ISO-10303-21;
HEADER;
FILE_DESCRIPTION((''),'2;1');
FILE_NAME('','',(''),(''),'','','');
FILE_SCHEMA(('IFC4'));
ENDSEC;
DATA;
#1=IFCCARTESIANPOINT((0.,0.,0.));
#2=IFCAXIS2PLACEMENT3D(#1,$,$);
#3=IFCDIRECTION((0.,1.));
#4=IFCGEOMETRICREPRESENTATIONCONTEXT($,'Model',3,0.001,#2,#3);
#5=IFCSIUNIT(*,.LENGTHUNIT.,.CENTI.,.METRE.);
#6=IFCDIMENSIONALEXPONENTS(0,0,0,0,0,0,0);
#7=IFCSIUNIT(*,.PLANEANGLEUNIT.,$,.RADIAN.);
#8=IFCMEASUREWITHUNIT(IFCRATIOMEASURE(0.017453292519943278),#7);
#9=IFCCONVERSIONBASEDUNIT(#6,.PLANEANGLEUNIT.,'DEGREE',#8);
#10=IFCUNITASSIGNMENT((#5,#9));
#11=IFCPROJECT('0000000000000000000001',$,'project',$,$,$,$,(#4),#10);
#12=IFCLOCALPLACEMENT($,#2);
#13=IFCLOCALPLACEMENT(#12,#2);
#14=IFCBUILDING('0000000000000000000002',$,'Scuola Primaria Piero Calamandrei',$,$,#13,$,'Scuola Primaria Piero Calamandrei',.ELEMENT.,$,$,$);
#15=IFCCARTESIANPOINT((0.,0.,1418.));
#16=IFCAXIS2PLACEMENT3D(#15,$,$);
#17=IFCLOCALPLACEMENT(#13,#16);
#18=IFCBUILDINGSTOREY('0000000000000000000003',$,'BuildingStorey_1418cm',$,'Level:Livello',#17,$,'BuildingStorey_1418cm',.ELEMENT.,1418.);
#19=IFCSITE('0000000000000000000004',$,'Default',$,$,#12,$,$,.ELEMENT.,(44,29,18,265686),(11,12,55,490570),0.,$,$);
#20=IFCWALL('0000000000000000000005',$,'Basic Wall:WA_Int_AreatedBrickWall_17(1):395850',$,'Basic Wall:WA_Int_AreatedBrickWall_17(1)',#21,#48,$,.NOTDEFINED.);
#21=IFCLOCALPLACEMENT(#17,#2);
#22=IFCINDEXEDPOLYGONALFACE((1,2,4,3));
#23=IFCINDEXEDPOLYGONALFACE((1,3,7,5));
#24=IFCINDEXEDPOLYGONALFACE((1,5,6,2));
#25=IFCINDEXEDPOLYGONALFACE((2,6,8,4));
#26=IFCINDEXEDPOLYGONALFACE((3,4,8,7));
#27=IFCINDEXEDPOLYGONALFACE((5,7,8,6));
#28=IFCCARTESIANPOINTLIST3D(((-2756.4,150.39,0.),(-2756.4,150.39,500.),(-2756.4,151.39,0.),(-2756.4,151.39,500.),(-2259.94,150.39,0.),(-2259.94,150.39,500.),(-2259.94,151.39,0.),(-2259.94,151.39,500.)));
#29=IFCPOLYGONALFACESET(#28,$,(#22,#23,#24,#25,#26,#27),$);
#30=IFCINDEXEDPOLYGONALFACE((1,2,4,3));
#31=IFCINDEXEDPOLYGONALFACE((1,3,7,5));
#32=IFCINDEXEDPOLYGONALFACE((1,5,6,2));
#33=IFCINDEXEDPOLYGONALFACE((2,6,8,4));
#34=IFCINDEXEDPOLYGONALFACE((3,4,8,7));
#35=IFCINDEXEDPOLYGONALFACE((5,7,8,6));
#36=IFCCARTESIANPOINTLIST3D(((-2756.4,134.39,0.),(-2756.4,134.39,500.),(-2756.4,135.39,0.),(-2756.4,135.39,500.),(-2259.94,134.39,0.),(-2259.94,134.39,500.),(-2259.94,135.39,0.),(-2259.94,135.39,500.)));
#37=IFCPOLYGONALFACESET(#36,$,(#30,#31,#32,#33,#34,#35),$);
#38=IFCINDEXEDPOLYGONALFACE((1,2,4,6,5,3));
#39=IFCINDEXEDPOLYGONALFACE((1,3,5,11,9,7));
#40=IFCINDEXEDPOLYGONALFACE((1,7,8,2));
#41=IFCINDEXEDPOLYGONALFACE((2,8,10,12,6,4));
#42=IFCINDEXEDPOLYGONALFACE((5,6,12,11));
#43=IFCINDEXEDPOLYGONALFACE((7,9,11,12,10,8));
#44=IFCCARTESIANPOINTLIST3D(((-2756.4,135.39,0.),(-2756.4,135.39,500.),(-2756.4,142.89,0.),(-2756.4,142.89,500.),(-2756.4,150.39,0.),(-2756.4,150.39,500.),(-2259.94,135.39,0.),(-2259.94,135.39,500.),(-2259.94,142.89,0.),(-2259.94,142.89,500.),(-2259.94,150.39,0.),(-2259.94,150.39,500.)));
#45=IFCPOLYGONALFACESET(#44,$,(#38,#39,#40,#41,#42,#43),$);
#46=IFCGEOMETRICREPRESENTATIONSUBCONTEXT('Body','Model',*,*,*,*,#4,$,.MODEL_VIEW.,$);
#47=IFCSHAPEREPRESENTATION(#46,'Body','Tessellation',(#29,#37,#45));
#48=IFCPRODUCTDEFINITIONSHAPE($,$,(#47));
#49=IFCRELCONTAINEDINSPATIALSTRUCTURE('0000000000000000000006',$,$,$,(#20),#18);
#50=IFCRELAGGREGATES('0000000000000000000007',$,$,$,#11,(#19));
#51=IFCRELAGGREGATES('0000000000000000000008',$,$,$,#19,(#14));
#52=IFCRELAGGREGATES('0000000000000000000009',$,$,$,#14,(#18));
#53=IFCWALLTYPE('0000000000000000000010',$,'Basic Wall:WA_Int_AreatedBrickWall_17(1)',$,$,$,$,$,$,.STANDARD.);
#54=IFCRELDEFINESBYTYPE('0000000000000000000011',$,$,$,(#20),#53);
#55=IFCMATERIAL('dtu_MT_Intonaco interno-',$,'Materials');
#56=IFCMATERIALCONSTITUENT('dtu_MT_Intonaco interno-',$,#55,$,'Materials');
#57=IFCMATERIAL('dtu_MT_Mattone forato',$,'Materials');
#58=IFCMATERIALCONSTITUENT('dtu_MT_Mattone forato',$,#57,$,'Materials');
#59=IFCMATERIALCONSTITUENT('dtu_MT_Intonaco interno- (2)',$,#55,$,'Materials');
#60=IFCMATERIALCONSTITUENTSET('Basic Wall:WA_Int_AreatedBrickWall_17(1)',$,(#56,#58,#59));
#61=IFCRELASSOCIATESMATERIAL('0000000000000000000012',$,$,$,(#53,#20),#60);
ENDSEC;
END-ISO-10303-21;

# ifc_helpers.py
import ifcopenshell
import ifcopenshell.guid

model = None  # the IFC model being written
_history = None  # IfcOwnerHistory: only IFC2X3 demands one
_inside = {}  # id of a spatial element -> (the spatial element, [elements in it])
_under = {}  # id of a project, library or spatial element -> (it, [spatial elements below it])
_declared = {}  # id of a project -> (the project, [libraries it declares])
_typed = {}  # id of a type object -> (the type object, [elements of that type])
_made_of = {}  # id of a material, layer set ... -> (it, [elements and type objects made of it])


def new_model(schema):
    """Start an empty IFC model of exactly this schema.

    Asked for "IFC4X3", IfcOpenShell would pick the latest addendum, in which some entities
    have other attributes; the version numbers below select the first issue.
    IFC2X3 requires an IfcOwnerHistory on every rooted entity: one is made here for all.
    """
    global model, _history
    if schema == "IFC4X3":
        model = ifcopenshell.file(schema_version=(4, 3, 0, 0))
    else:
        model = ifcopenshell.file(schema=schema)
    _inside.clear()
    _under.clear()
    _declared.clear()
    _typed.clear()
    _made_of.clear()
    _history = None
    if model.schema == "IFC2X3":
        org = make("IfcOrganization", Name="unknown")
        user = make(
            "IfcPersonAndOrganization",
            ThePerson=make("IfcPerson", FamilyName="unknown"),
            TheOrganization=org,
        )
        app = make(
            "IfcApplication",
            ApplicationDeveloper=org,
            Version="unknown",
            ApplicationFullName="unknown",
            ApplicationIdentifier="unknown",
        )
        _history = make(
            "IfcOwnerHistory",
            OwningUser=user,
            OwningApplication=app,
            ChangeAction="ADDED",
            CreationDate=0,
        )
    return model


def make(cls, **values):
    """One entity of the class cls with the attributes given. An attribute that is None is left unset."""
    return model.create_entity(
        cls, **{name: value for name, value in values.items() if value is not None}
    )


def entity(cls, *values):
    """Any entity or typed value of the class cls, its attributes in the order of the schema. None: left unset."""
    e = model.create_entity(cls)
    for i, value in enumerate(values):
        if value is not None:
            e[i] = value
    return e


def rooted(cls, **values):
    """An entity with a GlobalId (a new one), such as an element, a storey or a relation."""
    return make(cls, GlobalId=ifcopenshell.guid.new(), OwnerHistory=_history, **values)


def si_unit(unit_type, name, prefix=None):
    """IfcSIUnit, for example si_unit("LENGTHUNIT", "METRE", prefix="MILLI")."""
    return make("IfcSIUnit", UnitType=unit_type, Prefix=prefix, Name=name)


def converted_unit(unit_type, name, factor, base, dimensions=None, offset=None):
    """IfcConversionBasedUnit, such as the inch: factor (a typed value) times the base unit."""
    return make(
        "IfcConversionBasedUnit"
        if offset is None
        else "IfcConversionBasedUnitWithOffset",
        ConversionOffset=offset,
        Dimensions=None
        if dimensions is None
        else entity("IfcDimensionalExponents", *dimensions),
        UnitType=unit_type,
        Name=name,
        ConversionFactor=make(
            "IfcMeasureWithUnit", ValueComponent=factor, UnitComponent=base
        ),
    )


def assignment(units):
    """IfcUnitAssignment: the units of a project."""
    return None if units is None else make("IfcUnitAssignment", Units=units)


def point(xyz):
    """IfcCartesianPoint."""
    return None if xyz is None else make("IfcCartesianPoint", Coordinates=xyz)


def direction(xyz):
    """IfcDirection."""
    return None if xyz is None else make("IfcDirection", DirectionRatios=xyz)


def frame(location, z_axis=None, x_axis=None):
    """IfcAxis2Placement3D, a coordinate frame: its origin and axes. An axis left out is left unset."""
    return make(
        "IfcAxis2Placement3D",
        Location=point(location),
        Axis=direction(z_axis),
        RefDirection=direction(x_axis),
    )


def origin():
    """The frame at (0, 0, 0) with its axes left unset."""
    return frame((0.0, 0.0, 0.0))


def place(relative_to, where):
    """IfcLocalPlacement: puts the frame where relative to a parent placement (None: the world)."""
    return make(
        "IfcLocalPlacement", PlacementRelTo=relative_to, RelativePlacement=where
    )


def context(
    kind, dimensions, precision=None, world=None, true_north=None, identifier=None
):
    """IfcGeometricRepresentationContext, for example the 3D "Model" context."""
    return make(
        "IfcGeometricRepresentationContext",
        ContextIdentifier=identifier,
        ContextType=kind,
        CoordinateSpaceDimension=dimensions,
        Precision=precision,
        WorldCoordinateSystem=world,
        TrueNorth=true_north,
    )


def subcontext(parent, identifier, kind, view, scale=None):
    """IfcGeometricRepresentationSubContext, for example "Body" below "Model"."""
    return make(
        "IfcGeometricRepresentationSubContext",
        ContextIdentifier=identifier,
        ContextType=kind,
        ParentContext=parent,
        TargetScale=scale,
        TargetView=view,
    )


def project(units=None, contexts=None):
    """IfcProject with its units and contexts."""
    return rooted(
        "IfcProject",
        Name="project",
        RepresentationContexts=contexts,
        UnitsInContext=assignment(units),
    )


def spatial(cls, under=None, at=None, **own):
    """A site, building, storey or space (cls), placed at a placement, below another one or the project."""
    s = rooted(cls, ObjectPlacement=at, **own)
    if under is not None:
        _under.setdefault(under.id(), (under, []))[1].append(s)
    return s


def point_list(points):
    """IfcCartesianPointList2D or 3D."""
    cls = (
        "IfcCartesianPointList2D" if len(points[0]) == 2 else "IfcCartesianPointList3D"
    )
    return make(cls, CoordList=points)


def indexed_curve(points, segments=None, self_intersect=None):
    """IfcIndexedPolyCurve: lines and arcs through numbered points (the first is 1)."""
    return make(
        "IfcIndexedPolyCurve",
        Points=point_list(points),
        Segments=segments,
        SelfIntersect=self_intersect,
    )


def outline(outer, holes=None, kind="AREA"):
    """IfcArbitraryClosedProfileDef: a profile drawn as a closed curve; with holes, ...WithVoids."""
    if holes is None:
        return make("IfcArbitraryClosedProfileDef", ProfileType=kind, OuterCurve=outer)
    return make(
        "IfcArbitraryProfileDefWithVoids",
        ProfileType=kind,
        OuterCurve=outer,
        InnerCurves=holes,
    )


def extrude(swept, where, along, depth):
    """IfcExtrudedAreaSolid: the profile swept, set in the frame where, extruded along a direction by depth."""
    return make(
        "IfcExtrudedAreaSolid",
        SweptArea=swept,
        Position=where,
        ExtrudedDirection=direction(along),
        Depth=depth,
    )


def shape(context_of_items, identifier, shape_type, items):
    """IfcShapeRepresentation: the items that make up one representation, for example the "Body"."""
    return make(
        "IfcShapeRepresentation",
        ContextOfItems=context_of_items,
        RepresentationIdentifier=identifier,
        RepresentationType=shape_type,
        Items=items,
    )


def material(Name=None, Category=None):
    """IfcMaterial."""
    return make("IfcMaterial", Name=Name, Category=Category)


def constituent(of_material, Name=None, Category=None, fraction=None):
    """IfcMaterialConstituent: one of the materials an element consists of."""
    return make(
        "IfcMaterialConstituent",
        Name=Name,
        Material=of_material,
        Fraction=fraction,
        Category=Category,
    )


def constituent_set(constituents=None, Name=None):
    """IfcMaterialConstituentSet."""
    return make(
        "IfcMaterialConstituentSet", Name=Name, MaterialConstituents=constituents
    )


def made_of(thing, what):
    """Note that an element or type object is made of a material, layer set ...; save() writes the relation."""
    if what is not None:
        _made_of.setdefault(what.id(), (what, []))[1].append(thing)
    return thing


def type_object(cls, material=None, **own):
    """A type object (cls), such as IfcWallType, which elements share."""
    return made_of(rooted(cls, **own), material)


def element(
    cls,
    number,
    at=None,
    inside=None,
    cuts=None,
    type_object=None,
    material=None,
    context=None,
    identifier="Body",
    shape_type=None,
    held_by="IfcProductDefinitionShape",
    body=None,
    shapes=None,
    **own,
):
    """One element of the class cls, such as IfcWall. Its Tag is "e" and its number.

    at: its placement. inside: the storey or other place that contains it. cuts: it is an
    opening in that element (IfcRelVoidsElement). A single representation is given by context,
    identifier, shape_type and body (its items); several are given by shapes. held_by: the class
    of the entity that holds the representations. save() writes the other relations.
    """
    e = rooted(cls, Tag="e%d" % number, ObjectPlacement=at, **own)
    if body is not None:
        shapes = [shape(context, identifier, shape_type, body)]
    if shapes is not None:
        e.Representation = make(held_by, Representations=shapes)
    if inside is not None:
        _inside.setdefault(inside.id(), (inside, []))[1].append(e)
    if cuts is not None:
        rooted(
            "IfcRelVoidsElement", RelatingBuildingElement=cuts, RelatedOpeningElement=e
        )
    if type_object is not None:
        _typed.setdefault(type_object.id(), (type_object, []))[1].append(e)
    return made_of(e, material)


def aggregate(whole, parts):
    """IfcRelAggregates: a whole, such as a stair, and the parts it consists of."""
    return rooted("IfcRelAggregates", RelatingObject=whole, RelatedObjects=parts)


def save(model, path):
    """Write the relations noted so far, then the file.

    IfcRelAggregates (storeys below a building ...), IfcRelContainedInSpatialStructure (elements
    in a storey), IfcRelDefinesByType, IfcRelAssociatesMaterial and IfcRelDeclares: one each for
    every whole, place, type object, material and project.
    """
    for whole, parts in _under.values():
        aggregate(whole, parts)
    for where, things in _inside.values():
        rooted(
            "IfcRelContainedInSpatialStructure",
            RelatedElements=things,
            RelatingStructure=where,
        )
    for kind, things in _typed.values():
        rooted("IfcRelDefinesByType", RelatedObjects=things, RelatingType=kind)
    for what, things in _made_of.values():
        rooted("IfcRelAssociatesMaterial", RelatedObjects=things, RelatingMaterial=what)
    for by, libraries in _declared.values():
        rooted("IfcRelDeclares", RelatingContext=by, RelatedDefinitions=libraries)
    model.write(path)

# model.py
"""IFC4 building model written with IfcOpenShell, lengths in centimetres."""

from ifc_helpers import new_model, entity, si_unit, converted_unit, direction, frame, origin, place, context, subcontext, project, spatial, indexed_curve, outline, extrude, material, constituent, constituent_set, type_object, element, save


model = new_model("IFC4")

# Units and contexts
model_context = context("Model", 3, precision=0.001, world=origin(), true_north=direction((0.0, 1.0)))
body_context = subcontext(model_context, "Body", "Model", "MODEL_VIEW")
ifc_project = project(units=[si_unit("LENGTHUNIT", "METRE", prefix="CENTI"), converted_unit("PLANEANGLEUNIT", "DEGREE", entity("IfcRatioMeasure", 0.017453292519943278), si_unit("PLANEANGLEUNIT", "RADIAN"), dimensions=[0, 0, 0, 0, 0, 0, 0])], contexts=[model_context])

# Site, building, storey
site_placement = place(None, origin())
site = spatial("IfcSite", under=ifc_project, at=site_placement, Name="Default", CompositionType="ELEMENT", RefLatitude=(44, 29, 18, 265686), RefLongitude=(11, 12, 55, 490570), RefElevation=0.0)
building_placement = place(site_placement, origin())
building = spatial("IfcBuilding", under=site, at=building_placement, Name="Scuola Primaria Piero Calamandrei", LongName="Scuola Primaria Piero Calamandrei", CompositionType="ELEMENT")
storey_placement = place(building_placement, frame((0.0, 0.0, 1418.0)))
storey = spatial("IfcBuildingStorey", under=building, at=storey_placement, Name="BuildingStorey_1418cm", ObjectType="Level:Livello", LongName="BuildingStorey_1418cm", CompositionType="ELEMENT", Elevation=1418.0)

# Shared definitions
ifc_material_1 = material(Name="dtu_MT_Intonaco interno-", Category="Materials")

# Shared definitions
ifc_constituent_1 = constituent(ifc_material_1, Name="dtu_MT_Intonaco interno-", Category="Materials")
ifc_material_2 = material(Name="dtu_MT_Mattone forato", Category="Materials")
ifc_constituent_2 = constituent(ifc_material_2, Name="dtu_MT_Mattone forato", Category="Materials")
ifc_constituent_3 = constituent(ifc_material_1, Name="dtu_MT_Intonaco interno- (2)", Category="Materials")
ifc_constituent_set_1 = constituent_set(constituents=[ifc_constituent_1, ifc_constituent_2, ifc_constituent_3], Name="Basic Wall:WA_Int_AreatedBrickWall_17(1)")
wall_type_1 = type_object("IfcWallType", Name="Basic Wall:WA_Int_AreatedBrickWall_17(1)", PredefinedType="STANDARD", material=ifc_constituent_set_1)

# Wall
wall_1_placement = place(storey_placement, frame((-2259.94, 142.89, 0.0), z_axis=(0.0, 0.0, 1.0), x_axis=(-1.0, 0.0, 0.0)))
element("IfcWall", 1, at=wall_1_placement, inside=storey, type_object=wall_type_1, material=ifc_constituent_set_1, Name="Basic Wall:WA_Int_AreatedBrickWall_17(1):395850", ObjectType="Basic Wall:WA_Int_AreatedBrickWall_17(1)", PredefinedType="NOTDEFINED", context=body_context, shape_type="SweptSolid", body=[
    extrude(outline(indexed_curve([(-0.5, -248.23), (0.5, -248.23), (0.5, 248.23), (-0.5, 248.23), (-0.5, -248.23)], self_intersect=False)), frame((248.23, -8.0, 0.0), z_axis=(0.0, 0.0, 1.0), x_axis=(0.0, 1.0, 0.0)), (0.0, 0.0, 1.0), 500.0),
    extrude(outline(indexed_curve([(-0.5, -248.23), (0.5, -248.23), (0.5, 248.23), (-0.5, 248.23), (-0.5, -248.23)], self_intersect=False)), frame((248.23, 8.0, 0.0), z_axis=(0.0, 0.0, 1.0), x_axis=(0.0, -1.0, 0.0)), (0.0, 0.0, 1.0), 500.0),
    extrude(outline(indexed_curve([(-248.23, -7.5), (248.23, -7.5), (248.23, 0.0), (248.23, 7.5), (-248.23, 7.5), (-248.23, 0.0), (-248.23, -7.5)], self_intersect=False)), frame((248.23, 0.0, 0.0)), (0.0, 0.0, 1.0), 500.0),
])

save(model, "model.ifc")
